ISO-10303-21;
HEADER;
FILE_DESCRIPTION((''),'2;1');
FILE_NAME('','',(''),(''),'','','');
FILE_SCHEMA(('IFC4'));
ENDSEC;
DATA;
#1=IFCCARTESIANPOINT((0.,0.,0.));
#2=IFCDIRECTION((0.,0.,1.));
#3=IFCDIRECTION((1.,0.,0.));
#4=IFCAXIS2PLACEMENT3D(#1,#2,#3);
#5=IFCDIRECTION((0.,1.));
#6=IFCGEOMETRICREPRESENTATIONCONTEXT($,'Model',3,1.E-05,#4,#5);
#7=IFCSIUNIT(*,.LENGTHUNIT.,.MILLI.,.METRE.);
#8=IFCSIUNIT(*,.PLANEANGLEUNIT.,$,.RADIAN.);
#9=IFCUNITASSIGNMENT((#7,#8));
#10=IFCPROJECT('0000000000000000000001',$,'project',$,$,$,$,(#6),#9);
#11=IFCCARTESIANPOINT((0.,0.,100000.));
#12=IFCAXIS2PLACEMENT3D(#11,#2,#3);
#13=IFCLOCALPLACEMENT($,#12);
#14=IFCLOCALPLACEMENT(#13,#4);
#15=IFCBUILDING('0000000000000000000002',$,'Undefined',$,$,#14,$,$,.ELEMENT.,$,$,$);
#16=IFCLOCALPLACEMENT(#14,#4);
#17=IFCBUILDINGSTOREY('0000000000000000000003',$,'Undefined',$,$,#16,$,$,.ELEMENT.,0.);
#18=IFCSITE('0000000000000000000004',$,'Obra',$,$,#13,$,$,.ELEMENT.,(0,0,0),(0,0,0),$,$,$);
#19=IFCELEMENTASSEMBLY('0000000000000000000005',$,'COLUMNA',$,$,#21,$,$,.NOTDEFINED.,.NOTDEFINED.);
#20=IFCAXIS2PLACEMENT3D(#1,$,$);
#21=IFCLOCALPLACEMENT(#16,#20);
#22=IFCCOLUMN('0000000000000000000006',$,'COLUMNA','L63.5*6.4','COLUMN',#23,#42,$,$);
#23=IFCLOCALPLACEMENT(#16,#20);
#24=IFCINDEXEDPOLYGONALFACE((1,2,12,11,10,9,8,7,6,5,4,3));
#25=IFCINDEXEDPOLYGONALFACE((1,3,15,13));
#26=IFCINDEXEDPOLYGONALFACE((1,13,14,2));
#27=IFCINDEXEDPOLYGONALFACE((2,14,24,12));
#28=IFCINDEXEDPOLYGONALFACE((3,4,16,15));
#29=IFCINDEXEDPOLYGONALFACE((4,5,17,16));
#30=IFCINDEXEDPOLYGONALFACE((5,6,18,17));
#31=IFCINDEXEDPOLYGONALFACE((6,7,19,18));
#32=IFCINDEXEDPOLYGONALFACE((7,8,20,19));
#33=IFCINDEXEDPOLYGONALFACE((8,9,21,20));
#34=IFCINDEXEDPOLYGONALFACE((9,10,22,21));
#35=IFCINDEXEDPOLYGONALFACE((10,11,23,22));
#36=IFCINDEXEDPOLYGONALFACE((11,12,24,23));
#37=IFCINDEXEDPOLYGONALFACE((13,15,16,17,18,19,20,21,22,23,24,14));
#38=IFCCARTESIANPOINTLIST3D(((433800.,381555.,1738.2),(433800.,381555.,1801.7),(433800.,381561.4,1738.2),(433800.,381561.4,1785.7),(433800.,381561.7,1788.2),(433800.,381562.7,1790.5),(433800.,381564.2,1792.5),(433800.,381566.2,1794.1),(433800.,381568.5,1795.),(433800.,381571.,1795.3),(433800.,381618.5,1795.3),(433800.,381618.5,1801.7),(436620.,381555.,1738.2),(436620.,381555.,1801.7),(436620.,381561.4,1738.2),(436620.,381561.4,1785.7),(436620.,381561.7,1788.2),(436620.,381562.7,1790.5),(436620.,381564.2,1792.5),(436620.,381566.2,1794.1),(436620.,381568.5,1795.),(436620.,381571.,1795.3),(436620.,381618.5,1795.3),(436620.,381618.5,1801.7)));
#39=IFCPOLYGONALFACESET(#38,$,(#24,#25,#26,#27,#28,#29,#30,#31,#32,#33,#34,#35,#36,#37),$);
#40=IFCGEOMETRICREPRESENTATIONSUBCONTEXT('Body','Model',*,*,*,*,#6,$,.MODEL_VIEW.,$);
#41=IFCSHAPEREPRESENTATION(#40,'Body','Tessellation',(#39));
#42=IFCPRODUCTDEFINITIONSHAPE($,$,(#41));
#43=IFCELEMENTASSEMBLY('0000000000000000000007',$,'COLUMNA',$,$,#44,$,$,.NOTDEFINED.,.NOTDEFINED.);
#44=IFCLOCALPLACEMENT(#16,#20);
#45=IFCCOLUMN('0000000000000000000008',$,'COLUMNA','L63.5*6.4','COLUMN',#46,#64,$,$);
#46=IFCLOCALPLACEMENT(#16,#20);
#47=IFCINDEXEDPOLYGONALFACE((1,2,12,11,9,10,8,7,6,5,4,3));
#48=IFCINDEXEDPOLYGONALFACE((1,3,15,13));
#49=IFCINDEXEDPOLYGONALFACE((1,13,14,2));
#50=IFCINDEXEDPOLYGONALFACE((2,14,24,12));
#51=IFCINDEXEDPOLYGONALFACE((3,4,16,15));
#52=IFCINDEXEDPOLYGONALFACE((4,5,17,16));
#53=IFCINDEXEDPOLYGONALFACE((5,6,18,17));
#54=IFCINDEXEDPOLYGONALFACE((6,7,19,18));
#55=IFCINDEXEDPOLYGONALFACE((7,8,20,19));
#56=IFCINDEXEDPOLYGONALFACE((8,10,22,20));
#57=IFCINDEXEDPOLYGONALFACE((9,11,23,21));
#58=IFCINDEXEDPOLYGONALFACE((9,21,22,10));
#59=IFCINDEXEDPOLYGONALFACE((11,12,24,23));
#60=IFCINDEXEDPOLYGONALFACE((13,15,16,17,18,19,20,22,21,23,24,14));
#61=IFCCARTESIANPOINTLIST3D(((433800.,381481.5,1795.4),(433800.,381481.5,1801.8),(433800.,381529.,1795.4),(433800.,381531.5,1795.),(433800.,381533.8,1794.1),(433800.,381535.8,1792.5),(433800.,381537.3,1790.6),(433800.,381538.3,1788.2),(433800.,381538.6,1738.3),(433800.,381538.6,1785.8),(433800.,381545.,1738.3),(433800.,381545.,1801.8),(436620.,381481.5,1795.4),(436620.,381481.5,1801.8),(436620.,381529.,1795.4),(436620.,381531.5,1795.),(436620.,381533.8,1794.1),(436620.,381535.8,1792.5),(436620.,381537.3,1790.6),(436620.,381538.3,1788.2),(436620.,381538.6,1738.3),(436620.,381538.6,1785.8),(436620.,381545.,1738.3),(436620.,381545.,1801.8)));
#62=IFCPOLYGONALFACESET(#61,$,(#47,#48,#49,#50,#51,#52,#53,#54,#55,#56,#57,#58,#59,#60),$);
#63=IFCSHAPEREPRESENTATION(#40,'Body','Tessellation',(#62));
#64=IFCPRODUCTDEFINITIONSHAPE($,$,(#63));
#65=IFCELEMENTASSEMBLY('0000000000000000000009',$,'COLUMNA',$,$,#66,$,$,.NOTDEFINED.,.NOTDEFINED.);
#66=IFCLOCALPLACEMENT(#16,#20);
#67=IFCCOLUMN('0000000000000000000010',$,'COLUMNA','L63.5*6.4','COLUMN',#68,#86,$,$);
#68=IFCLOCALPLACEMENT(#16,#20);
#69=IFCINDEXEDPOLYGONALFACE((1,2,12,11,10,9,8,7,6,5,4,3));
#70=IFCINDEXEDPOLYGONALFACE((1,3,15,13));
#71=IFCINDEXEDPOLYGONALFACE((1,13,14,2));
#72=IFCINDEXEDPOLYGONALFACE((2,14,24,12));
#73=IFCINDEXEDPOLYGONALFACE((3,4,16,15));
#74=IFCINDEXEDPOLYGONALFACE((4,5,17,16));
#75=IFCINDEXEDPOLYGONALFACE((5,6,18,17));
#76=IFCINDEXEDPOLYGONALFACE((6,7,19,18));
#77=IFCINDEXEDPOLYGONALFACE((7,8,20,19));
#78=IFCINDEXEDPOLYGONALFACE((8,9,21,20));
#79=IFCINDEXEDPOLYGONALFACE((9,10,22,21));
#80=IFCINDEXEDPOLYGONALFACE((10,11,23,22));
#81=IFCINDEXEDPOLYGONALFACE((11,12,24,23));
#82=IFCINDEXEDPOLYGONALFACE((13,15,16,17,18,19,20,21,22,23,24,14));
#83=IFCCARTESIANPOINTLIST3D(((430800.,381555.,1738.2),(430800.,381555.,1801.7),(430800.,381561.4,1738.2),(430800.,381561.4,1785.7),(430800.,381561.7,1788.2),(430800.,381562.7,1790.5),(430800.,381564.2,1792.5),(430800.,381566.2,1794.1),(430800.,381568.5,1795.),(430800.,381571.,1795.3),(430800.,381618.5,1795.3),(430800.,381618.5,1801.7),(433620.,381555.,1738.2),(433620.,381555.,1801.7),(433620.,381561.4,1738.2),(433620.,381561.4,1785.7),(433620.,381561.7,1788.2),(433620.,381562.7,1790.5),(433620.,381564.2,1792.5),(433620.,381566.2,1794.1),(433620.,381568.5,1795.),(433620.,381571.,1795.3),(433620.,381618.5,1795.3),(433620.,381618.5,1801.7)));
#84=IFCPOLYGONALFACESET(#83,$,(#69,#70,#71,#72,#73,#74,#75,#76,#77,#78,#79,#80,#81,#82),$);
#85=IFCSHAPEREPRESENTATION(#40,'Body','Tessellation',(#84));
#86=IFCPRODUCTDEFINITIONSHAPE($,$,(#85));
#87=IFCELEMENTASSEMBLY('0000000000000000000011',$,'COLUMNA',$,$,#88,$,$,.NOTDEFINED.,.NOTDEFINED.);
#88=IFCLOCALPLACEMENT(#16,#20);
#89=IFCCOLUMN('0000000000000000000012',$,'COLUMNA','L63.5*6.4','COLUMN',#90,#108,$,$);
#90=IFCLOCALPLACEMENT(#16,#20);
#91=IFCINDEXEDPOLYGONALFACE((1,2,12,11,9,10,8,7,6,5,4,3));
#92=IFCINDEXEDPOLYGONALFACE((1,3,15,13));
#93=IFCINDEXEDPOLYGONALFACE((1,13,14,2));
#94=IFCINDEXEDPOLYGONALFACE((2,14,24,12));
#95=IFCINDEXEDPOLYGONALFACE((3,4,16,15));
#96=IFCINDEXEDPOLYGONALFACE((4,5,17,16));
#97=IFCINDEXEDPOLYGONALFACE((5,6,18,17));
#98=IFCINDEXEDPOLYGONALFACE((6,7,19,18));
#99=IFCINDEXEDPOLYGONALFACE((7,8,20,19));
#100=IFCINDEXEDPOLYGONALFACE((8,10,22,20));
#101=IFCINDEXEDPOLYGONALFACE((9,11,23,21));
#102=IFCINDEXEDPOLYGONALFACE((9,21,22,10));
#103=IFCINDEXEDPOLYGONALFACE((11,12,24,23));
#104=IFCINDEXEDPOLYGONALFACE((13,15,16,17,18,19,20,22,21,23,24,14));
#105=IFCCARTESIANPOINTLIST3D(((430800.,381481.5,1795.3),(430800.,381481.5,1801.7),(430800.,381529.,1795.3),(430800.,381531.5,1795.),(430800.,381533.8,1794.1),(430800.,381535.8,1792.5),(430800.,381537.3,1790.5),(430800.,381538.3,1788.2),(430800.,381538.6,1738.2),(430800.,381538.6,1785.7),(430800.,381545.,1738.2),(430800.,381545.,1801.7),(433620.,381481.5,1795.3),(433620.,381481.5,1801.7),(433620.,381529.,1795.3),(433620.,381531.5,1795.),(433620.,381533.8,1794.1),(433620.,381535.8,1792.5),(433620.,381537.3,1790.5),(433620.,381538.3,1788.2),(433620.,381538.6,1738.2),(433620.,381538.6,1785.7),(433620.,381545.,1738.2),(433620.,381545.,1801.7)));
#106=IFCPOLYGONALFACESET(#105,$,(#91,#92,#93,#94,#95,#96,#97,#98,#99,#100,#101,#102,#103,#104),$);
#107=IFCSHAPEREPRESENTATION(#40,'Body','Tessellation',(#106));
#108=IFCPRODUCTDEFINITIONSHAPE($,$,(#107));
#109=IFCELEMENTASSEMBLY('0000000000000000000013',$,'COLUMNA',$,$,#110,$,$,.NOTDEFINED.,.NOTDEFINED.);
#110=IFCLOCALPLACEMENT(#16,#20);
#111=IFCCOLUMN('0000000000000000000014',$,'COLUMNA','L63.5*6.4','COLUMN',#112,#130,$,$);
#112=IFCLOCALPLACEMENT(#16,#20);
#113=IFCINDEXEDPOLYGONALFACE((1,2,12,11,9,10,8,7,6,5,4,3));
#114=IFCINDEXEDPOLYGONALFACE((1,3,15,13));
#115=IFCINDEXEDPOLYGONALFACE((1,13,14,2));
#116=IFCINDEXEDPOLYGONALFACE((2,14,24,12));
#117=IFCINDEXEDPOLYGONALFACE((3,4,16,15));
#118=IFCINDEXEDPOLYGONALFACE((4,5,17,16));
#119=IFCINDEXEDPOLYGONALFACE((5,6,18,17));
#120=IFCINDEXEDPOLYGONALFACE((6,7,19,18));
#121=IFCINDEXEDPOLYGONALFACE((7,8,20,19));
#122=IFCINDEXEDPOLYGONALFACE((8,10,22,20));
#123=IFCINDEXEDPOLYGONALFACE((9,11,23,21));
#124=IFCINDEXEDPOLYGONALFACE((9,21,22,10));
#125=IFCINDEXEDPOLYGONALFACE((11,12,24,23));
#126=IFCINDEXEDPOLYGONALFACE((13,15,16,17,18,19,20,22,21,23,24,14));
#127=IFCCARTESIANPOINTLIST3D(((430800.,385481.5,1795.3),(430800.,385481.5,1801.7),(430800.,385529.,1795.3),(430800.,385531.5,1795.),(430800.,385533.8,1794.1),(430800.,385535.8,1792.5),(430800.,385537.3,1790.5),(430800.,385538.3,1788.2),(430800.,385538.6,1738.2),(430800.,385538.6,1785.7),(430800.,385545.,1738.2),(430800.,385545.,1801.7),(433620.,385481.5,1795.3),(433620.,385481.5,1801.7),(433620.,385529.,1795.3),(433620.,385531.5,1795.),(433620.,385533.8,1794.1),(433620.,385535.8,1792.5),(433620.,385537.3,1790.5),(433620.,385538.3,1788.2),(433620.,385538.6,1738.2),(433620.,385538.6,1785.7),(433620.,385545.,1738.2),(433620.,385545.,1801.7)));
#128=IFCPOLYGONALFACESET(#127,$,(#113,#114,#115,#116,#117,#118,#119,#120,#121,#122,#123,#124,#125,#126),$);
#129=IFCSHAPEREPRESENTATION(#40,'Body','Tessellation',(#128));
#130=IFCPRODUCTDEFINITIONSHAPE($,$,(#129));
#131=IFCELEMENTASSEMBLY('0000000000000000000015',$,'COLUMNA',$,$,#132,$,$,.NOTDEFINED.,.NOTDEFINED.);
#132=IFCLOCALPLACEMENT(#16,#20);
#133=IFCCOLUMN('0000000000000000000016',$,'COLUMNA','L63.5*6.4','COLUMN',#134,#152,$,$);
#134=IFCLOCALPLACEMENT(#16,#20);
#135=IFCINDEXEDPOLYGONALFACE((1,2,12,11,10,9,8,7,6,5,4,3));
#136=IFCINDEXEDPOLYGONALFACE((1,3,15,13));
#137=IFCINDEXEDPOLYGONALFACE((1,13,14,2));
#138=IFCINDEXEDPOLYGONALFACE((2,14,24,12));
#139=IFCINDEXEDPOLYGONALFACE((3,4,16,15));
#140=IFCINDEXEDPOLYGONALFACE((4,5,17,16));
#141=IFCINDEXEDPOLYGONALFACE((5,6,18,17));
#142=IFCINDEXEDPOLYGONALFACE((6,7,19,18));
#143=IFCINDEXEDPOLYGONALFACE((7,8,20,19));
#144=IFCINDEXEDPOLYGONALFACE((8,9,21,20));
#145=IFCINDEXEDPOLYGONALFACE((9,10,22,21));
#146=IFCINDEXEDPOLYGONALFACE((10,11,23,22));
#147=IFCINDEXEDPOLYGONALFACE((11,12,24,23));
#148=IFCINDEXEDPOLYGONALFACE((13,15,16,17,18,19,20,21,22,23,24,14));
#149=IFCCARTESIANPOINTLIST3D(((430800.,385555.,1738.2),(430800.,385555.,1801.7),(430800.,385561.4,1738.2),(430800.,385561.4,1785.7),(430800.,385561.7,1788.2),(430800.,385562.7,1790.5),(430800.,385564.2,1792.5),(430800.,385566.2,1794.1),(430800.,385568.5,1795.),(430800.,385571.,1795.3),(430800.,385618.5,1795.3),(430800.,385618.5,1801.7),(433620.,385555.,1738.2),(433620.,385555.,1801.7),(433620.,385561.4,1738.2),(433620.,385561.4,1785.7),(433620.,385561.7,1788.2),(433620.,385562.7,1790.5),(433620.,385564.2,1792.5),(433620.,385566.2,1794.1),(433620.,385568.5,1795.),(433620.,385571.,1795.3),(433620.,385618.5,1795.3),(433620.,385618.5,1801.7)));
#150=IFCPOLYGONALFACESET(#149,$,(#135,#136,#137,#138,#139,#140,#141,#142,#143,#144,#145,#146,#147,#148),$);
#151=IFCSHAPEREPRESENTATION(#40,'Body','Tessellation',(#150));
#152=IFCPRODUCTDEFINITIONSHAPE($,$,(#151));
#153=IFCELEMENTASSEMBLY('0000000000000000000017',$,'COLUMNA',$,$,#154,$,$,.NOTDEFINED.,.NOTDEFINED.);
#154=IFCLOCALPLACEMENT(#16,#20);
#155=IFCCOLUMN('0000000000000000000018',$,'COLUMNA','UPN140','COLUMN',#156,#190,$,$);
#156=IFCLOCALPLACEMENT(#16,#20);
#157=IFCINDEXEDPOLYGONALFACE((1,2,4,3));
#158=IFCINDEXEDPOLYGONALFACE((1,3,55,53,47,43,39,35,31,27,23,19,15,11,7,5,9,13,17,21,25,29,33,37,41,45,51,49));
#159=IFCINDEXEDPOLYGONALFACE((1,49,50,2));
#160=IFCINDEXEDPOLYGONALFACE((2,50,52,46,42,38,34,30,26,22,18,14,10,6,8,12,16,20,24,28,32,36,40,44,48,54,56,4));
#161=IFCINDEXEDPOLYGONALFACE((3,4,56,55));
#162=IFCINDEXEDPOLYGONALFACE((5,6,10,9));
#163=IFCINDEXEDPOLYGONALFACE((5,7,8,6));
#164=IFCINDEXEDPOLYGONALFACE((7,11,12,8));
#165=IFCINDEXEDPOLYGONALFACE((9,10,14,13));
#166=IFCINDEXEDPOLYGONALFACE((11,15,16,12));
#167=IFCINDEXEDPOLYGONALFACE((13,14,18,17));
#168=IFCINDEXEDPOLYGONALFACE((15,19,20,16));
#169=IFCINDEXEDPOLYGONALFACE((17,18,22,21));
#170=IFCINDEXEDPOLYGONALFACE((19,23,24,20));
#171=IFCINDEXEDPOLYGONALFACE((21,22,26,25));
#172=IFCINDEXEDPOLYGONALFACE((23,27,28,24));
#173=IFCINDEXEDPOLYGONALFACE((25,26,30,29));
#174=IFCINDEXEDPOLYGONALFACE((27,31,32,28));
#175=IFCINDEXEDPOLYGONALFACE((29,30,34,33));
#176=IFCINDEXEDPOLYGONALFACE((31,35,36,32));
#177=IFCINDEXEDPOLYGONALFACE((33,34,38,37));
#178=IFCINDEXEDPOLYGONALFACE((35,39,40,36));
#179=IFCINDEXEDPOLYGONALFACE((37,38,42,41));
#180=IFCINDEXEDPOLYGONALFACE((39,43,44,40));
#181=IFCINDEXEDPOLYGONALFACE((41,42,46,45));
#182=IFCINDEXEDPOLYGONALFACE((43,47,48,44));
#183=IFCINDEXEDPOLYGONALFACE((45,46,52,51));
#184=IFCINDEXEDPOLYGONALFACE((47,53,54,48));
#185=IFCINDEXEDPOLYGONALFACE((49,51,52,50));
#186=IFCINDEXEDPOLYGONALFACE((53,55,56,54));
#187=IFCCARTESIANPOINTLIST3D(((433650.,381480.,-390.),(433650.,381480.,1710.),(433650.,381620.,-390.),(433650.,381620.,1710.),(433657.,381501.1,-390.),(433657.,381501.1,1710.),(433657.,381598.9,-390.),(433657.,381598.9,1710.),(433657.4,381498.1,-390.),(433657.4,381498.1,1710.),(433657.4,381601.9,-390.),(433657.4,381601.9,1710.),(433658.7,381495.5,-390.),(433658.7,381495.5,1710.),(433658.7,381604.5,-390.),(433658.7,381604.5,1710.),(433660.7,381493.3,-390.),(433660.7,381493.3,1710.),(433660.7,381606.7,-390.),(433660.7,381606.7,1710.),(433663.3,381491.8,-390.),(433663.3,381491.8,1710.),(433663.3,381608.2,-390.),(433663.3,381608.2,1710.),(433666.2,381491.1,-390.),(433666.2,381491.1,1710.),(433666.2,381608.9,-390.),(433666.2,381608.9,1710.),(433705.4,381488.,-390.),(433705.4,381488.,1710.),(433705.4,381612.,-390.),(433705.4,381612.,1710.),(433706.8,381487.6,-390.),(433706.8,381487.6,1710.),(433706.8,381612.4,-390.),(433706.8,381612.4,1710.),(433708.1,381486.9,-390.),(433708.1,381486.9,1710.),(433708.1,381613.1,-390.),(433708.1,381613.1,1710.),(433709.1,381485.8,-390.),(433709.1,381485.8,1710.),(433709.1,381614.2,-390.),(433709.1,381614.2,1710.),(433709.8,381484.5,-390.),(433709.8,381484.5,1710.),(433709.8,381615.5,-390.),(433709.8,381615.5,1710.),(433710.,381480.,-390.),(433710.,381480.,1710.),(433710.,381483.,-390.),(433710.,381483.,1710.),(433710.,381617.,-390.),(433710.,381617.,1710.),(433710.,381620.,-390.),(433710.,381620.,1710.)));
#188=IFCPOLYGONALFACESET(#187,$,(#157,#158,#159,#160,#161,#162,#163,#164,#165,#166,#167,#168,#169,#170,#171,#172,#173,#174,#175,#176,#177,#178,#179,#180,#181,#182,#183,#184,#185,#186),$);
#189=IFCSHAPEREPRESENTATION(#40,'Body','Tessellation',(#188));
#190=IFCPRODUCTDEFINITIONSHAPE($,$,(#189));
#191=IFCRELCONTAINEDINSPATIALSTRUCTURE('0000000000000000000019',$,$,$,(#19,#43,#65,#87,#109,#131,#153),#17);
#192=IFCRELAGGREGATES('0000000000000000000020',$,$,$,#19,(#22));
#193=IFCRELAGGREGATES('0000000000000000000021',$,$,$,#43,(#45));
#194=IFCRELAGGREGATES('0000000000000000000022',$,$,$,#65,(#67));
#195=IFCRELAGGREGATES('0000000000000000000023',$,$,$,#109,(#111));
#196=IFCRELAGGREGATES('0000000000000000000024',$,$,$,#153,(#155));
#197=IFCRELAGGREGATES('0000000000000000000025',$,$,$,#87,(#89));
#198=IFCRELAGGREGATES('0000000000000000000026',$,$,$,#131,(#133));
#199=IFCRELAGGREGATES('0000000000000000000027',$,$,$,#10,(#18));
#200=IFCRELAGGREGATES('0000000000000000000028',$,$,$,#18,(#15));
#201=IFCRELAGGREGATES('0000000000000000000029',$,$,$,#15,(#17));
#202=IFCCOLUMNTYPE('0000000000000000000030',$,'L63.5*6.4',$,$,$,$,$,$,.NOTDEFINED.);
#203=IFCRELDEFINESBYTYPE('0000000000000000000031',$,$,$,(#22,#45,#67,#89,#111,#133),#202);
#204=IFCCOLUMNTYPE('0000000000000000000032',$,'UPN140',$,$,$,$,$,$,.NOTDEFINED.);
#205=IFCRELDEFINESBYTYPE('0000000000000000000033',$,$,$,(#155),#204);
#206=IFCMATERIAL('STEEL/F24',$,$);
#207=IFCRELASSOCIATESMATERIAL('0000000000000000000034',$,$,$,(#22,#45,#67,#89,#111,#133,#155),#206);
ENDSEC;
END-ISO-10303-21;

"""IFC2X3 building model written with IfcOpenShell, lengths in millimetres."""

from ifc_helpers import new_model, si_unit, direction, frame, origin_with_axes, origin_2d_with_axis, place, context, subcontext, project, spatial, l_section, u_section, extrude, material, type_object, element, aggregate, save


model = new_model("IFC2X3")

# Units and contexts
model_context = context("Model", 3, precision=1e-05, world=origin_with_axes(), true_north=direction((0.0, 1.0)))
body_context = subcontext(model_context, "Body", "Model", "MODEL_VIEW")
ifc_project = project(units=[si_unit("LENGTHUNIT", "METRE", prefix="MILLI"), si_unit("PLANEANGLEUNIT", "RADIAN")], contexts=[model_context])

# Site, building, storey
site_placement = place(None, frame((0.0, 0.0, 100000.0), z_axis=(0.0, 0.0, 1.0), x_axis=(1.0, 0.0, 0.0)))
site = spatial("IfcSite", under=ifc_project, at=site_placement, Name="Obra", CompositionType="ELEMENT", RefLatitude=(0, 0, 0), RefLongitude=(0, 0, 0))
building_placement = place(site_placement, origin_with_axes())
building = spatial("IfcBuilding", under=site, at=building_placement, Name="Undefined", CompositionType="ELEMENT")
storey_placement = place(building_placement, origin_with_axes())
storey = spatial("IfcBuildingStorey", under=building, at=storey_placement, Name="Undefined", CompositionType="ELEMENT", Elevation=0.0)

# Element assemblies, columns
assembly_1_placement = place(storey_placement, origin_with_axes())
assembly_1 = element("IfcElementAssembly", 1, at=assembly_1_placement, inside=storey, Name="COLUMNA", AssemblyPlace="NOTDEFINED", PredefinedType="NOTDEFINED")
ifc_material_1 = material(Name="STEEL/F24")
column_type_1 = type_object("IfcColumnType", Name="L63.5*6.4", PredefinedType="NOTDEFINED")
column_1_placement = place(assembly_1_placement, frame((433800.0, 381586.7, 1770.0), z_axis=(1.0, 0.0, 0.0), x_axis=(0.0, 0.0, -1.0)))
column_1 = element("IfcColumn", 2, at=column_1_placement, type_object=column_type_1, material=ifc_material_1, Name="COLUMNA", Description="L63.5*6.4", ObjectType="COLUMN", context=body_context, shape_type="SweptSolid", body=[
    extrude(l_section(Depth=63.5, Width=63.5, Thickness=6.4, FilletRadius=9.6, at=origin_2d_with_axis()), frame((0.0, 0.0, 2820.0), z_axis=(0.0, 0.0, -1.0), x_axis=(0.0, 1.0, 0.0)), (0.0, 0.0, 1.0), 2820.0),
])
aggregate(assembly_1, [column_1])
assembly_2_placement = place(storey_placement, origin_with_axes())
assembly_2 = element("IfcElementAssembly", 3, at=assembly_2_placement, inside=storey, Name="COLUMNA", AssemblyPlace="NOTDEFINED", PredefinedType="NOTDEFINED")
column_2_placement = place(assembly_2_placement, frame((433800.0, 381513.2, 1770.0), z_axis=(1.0, 0.0, 0.0), x_axis=(0.0, -1.0, 0.0)))
column_2 = element("IfcColumn", 4, at=column_2_placement, type_object=column_type_1, material=ifc_material_1, Name="COLUMNA", Description="L63.5*6.4", ObjectType="COLUMN", context=body_context, shape_type="SweptSolid", body=[
    extrude(l_section(Depth=63.5, Width=63.5, Thickness=6.4, FilletRadius=9.6, at=origin_2d_with_axis()), frame((0.0, 0.0, 2820.0), z_axis=(0.0, 0.0, -1.0), x_axis=(0.0, 1.0, 0.0)), (0.0, 0.0, 1.0), 2820.0),
])
aggregate(assembly_2, [column_2])
assembly_3_placement = place(storey_placement, origin_with_axes())
assembly_3 = element("IfcElementAssembly", 5, at=assembly_3_placement, inside=storey, Name="COLUMNA", AssemblyPlace="NOTDEFINED", PredefinedType="NOTDEFINED")
column_3_placement = place(assembly_3_placement, frame((430800.0, 381586.7, 1770.0), z_axis=(1.0, 0.0, 0.0), x_axis=(0.0, 0.0, -1.0)))
column_3 = element("IfcColumn", 6, at=column_3_placement, type_object=column_type_1, material=ifc_material_1, Name="COLUMNA", Description="L63.5*6.4", ObjectType="COLUMN", context=body_context, shape_type="SweptSolid", body=[
    extrude(l_section(Depth=63.5, Width=63.5, Thickness=6.4, FilletRadius=9.6, at=origin_2d_with_axis()), frame((0.0, 0.0, 2820.0), z_axis=(0.0, 0.0, -1.0), x_axis=(0.0, 1.0, 0.0)), (0.0, 0.0, 1.0), 2820.0),
])
aggregate(assembly_3, [column_3])
assembly_4_placement = place(storey_placement, origin_with_axes())
assembly_4 = element("IfcElementAssembly", 7, at=assembly_4_placement, inside=storey, Name="COLUMNA", AssemblyPlace="NOTDEFINED", PredefinedType="NOTDEFINED")
column_4_placement = place(assembly_4_placement, frame((430800.0, 381513.2, 1770.0), z_axis=(1.0, 0.0, 0.0), x_axis=(0.0, -1.0, 0.0)))
column_4 = element("IfcColumn", 8, at=column_4_placement, type_object=column_type_1, material=ifc_material_1, Name="COLUMNA", Description="L63.5*6.4", ObjectType="COLUMN", context=body_context, shape_type="SweptSolid", body=[
    extrude(l_section(Depth=63.5, Width=63.5, Thickness=6.4, FilletRadius=9.6, at=origin_2d_with_axis()), frame((0.0, 0.0, 2820.0), z_axis=(0.0, 0.0, -1.0), x_axis=(0.0, 1.0, 0.0)), (0.0, 0.0, 1.0), 2820.0),
])
assembly_5_placement = place(storey_placement, origin_with_axes())
assembly_5 = element("IfcElementAssembly", 9, at=assembly_5_placement, inside=storey, Name="COLUMNA", AssemblyPlace="NOTDEFINED", PredefinedType="NOTDEFINED")
column_5_placement = place(assembly_5_placement, frame((433620.0, 385513.3, 1770.0), z_axis=(-1.0, 0.0, 0.0), x_axis=(0.0, 0.0, -1.0)))
column_5 = element("IfcColumn", 10, at=column_5_placement, type_object=column_type_1, material=ifc_material_1, Name="COLUMNA", Description="L63.5*6.4", ObjectType="COLUMN", context=body_context, shape_type="SweptSolid", body=[
    extrude(l_section(Depth=63.5, Width=63.5, Thickness=6.4, FilletRadius=9.6, at=origin_2d_with_axis()), frame((0.0, 0.0, 2820.0), z_axis=(0.0, 0.0, -1.0), x_axis=(0.0, 1.0, 0.0)), (0.0, 0.0, 1.0), 2820.0),
])
aggregate(assembly_5, [column_5])
assembly_6_placement = place(storey_placement, origin_with_axes())
assembly_6 = element("IfcElementAssembly", 11, at=assembly_6_placement, inside=storey, Name="COLUMNA", AssemblyPlace="NOTDEFINED", PredefinedType="NOTDEFINED")
column_6_placement = place(assembly_6_placement, frame((433620.0, 385586.8, 1770.0), z_axis=(-1.0, 0.0, 0.0), x_axis=(0.0, 1.0, 0.0)))
column_6 = element("IfcColumn", 12, at=column_6_placement, type_object=column_type_1, material=ifc_material_1, Name="COLUMNA", Description="L63.5*6.4", ObjectType="COLUMN", context=body_context, shape_type="SweptSolid", body=[
    extrude(l_section(Depth=63.5, Width=63.5, Thickness=6.4, FilletRadius=9.6, at=origin_2d_with_axis()), frame((0.0, 0.0, 2820.0), z_axis=(0.0, 0.0, -1.0), x_axis=(0.0, 1.0, 0.0)), (0.0, 0.0, 1.0), 2820.0),
])
assembly_7_placement = place(storey_placement, origin_with_axes())
assembly_7 = element("IfcElementAssembly", 13, at=assembly_7_placement, inside=storey, Name="COLUMNA", AssemblyPlace="NOTDEFINED", PredefinedType="NOTDEFINED")
column_type_2 = type_object("IfcColumnType", Name="UPN140", PredefinedType="NOTDEFINED")
column_7_placement = place(assembly_7_placement, frame((433680.0, 381550.0, 1710.0), z_axis=(0.0, 0.0, -1.0), x_axis=(0.0, 1.0, 0.0)))
column_7 = element("IfcColumn", 14, at=column_7_placement, type_object=column_type_2, material=ifc_material_1, Name="COLUMNA", Description="UPN140", ObjectType="COLUMN", context=body_context, shape_type="SweptSolid", body=[
    extrude(u_section(Depth=140.0, FlangeWidth=60.0, WebThickness=7.0, FlangeThickness=10.0, FilletRadius=10.0, EdgeRadius=5.0, FlangeSlope=0.07983, at=origin_2d_with_axis()), frame((0.0, 0.0, 2100.0), z_axis=(0.0, 0.0, -1.0), x_axis=(0.0, 1.0, 0.0)), (0.0, 0.0, 1.0), 2100.0),
])
aggregate(assembly_7, [column_7])

aggregate(assembly_4, [column_4])
aggregate(assembly_6, [column_6])

save(model, "model.ifc")
